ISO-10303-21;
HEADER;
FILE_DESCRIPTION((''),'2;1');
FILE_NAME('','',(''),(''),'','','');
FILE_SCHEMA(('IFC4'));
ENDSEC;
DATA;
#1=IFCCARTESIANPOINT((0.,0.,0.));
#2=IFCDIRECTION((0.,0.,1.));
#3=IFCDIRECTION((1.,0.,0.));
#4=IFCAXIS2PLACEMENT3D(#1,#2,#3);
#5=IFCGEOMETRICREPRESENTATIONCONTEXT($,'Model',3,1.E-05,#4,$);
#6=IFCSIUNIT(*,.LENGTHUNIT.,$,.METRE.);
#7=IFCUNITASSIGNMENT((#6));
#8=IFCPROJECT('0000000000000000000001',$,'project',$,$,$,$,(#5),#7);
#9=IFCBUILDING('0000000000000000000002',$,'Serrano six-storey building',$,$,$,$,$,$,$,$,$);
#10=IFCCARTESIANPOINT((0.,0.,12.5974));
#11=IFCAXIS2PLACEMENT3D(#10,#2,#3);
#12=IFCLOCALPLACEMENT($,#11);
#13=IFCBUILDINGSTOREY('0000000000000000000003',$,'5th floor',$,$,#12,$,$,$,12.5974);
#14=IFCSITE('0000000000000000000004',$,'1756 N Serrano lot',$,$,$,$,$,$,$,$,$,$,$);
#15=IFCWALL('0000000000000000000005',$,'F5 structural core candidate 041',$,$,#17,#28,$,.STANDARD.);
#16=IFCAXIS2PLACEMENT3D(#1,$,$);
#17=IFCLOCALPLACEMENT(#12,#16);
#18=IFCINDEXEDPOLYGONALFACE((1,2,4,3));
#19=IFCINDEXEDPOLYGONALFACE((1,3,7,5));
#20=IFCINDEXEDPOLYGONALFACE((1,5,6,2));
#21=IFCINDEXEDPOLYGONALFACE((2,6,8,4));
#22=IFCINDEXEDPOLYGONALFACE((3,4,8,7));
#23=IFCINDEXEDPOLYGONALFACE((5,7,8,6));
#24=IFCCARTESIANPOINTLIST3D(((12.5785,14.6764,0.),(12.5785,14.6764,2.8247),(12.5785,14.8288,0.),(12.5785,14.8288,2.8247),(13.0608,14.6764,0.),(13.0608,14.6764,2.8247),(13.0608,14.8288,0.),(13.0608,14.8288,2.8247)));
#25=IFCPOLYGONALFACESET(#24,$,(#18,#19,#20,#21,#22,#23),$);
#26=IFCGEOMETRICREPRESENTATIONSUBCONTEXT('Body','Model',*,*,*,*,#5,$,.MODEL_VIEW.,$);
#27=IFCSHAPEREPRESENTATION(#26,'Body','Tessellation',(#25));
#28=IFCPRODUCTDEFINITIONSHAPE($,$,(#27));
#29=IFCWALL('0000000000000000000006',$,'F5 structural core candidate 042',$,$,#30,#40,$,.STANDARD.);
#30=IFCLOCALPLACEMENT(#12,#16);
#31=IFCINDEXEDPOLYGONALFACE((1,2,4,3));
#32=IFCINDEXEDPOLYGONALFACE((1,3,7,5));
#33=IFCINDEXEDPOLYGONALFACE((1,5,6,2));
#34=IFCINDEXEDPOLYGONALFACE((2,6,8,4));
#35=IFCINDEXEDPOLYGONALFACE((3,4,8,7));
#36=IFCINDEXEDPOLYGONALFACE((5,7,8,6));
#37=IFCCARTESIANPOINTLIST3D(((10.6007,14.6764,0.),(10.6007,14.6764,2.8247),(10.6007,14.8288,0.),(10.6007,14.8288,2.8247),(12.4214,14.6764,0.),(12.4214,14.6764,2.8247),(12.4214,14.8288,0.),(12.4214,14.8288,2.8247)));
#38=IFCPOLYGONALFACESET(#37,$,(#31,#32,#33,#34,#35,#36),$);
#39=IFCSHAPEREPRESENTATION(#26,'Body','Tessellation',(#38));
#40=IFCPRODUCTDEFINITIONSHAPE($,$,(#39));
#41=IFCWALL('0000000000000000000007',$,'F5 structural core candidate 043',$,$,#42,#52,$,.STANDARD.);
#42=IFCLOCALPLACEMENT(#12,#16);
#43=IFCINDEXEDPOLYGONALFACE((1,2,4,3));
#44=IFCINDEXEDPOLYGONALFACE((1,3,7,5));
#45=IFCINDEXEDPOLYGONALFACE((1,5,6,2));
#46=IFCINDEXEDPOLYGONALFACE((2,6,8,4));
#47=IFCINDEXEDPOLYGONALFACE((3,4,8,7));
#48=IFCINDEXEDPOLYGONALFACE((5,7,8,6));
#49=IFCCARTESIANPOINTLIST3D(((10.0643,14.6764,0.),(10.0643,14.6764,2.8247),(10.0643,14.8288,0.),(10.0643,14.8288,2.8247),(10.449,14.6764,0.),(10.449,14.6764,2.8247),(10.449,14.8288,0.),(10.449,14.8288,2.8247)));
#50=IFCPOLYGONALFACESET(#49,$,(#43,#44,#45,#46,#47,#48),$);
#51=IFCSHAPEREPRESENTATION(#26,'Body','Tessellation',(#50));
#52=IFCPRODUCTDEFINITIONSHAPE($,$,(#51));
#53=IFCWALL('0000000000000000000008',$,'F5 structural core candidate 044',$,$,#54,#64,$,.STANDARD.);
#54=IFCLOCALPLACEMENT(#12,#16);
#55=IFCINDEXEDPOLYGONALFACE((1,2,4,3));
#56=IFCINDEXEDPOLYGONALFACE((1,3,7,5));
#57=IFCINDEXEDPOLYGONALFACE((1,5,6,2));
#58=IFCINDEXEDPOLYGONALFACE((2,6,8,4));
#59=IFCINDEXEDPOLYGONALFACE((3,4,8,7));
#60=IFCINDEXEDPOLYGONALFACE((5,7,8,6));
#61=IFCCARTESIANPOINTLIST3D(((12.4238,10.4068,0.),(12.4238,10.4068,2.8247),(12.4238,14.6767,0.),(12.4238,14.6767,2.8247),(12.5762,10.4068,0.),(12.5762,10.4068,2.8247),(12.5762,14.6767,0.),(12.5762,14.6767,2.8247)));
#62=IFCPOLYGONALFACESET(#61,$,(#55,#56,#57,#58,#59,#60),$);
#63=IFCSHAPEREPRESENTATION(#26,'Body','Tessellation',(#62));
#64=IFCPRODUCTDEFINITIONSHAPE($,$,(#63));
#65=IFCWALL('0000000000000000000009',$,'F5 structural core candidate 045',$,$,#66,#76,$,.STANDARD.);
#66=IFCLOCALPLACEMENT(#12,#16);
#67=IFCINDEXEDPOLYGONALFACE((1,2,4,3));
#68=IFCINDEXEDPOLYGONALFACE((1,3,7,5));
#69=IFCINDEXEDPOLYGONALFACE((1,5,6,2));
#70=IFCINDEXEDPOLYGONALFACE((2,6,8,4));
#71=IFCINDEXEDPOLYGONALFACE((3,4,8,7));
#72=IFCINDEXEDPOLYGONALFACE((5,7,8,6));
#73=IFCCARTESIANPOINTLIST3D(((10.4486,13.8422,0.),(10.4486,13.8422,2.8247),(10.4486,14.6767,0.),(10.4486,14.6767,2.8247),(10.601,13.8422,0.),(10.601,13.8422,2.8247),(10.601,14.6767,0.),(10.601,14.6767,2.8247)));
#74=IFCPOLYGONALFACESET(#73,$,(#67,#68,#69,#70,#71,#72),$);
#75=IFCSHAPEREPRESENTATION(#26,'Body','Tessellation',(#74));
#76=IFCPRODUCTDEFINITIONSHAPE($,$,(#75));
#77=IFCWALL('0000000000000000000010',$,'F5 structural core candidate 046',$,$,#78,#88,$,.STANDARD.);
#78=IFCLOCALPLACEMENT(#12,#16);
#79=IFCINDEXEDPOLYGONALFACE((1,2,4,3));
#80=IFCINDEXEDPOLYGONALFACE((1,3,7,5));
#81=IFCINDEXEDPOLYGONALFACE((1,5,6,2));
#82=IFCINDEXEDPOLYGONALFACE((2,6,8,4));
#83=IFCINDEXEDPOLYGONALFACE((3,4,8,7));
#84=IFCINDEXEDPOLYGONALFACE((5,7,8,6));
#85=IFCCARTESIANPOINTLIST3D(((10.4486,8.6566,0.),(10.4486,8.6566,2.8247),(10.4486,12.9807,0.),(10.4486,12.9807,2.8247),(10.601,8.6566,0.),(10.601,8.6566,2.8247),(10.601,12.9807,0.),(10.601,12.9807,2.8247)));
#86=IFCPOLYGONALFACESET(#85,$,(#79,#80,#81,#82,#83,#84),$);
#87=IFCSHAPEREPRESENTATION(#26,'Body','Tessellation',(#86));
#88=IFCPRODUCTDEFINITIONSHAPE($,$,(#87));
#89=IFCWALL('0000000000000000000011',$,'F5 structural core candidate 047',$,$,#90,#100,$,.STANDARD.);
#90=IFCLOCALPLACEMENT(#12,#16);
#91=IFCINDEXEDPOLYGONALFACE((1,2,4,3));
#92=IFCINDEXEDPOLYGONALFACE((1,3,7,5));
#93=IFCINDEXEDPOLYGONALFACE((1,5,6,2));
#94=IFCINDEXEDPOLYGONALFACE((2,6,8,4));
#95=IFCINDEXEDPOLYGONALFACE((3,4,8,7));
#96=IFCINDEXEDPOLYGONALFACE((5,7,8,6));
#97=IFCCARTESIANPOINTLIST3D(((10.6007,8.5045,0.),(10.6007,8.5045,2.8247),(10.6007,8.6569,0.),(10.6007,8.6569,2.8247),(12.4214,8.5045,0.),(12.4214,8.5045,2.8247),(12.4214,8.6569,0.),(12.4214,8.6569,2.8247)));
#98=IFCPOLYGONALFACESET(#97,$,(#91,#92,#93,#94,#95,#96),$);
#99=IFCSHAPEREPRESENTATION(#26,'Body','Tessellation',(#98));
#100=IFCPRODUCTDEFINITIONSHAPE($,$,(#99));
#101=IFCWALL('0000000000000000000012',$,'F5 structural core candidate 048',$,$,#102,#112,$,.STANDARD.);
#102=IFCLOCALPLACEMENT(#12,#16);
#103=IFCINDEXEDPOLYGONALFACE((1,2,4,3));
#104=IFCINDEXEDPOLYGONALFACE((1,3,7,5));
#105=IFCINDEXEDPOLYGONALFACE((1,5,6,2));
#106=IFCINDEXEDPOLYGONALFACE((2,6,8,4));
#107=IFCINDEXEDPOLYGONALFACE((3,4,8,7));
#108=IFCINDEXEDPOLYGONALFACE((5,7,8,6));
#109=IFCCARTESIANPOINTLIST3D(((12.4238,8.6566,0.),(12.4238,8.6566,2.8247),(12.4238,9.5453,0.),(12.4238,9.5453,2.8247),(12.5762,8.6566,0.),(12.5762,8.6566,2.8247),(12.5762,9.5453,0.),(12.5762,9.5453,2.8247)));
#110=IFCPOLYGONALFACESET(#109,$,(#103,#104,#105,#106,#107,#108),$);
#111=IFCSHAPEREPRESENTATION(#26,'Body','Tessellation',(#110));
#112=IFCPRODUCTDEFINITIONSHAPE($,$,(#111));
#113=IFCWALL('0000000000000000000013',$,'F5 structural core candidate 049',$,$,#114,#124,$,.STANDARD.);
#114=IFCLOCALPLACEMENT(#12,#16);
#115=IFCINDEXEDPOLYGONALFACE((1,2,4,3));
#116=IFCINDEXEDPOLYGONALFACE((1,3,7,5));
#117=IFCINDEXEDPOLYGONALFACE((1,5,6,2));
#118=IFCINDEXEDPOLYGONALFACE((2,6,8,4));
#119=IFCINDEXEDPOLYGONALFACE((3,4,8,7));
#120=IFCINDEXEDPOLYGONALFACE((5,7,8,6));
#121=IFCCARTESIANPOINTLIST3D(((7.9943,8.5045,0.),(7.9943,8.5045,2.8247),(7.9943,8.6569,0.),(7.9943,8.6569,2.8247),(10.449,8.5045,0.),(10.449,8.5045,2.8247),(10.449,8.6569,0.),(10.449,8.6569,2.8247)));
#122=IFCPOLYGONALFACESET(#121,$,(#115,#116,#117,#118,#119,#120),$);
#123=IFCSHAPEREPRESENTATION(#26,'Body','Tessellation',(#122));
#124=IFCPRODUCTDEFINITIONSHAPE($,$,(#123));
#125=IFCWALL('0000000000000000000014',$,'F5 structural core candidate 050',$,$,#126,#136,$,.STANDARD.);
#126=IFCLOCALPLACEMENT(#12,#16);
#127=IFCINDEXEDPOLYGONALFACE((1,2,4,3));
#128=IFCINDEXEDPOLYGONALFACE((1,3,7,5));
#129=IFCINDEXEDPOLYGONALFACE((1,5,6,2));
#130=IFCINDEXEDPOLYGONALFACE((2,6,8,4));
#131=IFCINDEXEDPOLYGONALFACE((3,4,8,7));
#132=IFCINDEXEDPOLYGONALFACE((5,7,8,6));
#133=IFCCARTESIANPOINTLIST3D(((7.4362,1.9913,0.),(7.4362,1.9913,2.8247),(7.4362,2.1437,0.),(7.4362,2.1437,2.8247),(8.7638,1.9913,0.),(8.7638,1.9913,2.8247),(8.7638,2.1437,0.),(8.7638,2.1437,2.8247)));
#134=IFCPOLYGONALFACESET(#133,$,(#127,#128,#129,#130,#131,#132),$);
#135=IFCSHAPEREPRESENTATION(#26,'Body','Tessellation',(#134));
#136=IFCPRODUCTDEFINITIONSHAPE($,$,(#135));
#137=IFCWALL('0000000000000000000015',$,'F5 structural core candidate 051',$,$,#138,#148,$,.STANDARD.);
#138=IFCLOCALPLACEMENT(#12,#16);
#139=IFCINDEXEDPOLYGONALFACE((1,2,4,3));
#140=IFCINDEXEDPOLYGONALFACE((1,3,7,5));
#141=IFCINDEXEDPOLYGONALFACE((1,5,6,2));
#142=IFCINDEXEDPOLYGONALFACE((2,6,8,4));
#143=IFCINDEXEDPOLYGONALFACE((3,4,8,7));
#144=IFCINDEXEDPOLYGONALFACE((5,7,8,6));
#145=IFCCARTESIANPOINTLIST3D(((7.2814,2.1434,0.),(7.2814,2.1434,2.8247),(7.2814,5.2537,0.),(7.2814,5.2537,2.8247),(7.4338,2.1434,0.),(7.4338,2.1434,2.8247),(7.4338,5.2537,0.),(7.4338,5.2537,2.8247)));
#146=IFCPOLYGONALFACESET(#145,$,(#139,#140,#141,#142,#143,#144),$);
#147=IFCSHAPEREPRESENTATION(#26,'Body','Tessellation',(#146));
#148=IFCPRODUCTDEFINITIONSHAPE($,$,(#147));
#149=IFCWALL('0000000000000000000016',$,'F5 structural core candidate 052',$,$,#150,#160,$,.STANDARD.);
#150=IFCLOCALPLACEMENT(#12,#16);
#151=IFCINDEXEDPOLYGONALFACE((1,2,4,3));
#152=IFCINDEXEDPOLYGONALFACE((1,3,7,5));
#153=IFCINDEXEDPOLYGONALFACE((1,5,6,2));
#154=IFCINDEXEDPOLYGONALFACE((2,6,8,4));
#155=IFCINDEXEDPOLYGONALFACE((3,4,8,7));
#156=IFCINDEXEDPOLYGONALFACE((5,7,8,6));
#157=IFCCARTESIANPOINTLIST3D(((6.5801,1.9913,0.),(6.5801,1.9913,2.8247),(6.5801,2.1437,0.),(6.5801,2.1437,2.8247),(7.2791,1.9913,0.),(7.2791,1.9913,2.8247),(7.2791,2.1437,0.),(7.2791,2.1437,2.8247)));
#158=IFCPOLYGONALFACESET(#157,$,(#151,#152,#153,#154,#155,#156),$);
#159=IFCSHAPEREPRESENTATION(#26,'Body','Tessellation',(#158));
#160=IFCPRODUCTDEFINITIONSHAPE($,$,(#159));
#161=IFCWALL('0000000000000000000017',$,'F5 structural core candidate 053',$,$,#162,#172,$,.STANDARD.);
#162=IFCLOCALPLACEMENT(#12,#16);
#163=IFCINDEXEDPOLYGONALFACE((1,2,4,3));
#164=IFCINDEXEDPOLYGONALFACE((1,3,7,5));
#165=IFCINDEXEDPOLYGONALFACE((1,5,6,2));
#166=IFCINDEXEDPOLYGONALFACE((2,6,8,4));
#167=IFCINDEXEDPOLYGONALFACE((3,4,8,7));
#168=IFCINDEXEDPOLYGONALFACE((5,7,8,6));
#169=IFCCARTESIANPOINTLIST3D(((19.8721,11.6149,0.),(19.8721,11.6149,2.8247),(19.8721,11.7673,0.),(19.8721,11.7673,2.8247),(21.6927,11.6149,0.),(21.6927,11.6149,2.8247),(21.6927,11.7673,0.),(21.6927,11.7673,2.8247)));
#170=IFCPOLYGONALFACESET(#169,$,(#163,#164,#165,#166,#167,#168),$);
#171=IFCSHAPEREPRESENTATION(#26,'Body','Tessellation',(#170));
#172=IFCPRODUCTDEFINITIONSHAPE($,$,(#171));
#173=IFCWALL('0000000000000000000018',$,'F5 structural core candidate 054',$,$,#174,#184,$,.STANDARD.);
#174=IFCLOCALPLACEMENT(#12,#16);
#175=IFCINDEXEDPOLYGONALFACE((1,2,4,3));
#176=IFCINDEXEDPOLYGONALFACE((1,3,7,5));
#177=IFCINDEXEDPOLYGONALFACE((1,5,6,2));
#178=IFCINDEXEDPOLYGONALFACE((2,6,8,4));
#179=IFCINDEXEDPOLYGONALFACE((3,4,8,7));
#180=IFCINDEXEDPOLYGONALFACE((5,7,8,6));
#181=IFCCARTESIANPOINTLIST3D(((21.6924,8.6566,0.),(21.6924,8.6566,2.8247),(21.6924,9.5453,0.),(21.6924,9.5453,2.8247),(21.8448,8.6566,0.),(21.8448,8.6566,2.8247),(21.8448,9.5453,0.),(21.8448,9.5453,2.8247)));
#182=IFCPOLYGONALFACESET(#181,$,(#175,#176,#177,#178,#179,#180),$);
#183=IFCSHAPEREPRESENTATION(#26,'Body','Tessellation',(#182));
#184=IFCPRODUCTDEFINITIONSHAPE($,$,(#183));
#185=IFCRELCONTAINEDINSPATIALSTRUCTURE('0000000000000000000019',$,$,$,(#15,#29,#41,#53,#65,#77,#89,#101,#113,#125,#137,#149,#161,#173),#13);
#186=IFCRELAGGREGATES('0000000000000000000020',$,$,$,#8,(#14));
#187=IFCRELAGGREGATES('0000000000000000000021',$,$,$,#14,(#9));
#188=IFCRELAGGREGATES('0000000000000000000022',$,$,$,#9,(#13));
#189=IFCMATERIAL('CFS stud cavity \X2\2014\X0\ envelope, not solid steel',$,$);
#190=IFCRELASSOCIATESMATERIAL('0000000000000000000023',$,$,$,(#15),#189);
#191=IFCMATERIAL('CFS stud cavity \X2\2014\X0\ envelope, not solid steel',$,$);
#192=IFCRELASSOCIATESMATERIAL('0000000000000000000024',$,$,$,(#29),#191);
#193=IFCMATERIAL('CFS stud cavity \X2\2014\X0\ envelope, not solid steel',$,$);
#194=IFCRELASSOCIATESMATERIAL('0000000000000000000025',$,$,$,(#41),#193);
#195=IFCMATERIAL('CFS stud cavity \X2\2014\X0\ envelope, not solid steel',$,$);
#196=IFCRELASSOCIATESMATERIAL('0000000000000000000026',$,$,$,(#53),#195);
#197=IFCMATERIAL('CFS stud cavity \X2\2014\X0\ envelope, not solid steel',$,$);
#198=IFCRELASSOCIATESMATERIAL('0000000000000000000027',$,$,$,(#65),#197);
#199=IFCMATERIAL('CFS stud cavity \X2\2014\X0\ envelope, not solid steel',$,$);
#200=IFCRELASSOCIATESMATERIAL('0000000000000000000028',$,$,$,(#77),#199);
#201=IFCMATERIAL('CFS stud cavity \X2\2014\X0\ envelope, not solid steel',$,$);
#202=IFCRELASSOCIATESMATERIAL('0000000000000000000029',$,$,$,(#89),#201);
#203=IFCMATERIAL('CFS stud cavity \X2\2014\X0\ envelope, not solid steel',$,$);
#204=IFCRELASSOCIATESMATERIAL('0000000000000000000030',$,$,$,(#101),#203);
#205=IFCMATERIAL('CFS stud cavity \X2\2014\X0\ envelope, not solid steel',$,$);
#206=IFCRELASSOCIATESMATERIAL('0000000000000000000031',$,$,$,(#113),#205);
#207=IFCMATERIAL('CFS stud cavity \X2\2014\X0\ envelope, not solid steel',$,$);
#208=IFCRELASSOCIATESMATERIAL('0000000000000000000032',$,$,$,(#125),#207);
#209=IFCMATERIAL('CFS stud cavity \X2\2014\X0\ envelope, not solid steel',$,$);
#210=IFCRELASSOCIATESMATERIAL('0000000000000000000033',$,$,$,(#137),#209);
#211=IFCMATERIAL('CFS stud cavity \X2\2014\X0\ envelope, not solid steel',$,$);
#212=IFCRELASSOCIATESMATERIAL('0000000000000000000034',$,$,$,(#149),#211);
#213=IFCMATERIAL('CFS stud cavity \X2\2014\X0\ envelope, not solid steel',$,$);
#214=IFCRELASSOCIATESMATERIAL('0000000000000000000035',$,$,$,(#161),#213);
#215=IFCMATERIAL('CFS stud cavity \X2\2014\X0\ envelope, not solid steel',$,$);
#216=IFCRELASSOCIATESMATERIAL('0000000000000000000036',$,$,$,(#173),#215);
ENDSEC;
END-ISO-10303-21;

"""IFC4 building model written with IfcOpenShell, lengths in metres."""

from ifc_helpers import new_model, si_unit, frame, origin_with_axes, place, context, subcontext, project, spatial, polyline, outline, extrude, material, element, save


model = new_model("IFC4")

# Units and contexts
model_context = context("Model", 3, precision=1e-05, world=origin_with_axes())
body_context = subcontext(model_context, "Body", "Model", "MODEL_VIEW")
ifc_project = project(units=[si_unit("LENGTHUNIT", "METRE")], contexts=[model_context])

# Site, building, storey
site = spatial("IfcSite", under=ifc_project, Name="1756 N Serrano lot")
building = spatial("IfcBuilding", under=site, Name="Serrano six-storey building")
storey_placement = place(None, frame((0.0, 0.0, 12.5974), z_axis=(0.0, 0.0, 1.0), x_axis=(1.0, 0.0, 0.0)))
storey = spatial("IfcBuildingStorey", under=building, at=storey_placement, Name="5th floor", Elevation=12.5974)

# Walls
ifc_material_1 = material(Name="CFS stud cavity — envelope, not solid steel")
wall_1_placement = place(storey_placement, frame((0.0, 0.0, -12.5974), z_axis=(0.0, 0.0, 1.0), x_axis=(1.0, 0.0, 0.0)))
element("IfcWall", 1, at=wall_1_placement, inside=storey, material=ifc_material_1, Name="F5 structural core candidate 041", PredefinedType="STANDARD", context=body_context, shape_type="SweptSolid", body=[
    extrude(outline(polyline([(13.0608, 14.8288), (13.0608, 14.6764), (12.5785, 14.6764), (12.5785, 14.8288), (13.0608, 14.8288)])), frame((0.0, 0.0, 12.5974)), (0.0, 0.0, 1.0), 2.8247),
])
ifc_material_2 = material(Name="CFS stud cavity — envelope, not solid steel")
wall_2_placement = place(storey_placement, frame((0.0, 0.0, -12.5974), z_axis=(0.0, 0.0, 1.0), x_axis=(1.0, 0.0, 0.0)))
element("IfcWall", 2, at=wall_2_placement, inside=storey, material=ifc_material_2, Name="F5 structural core candidate 042", PredefinedType="STANDARD", context=body_context, shape_type="SweptSolid", body=[
    extrude(outline(polyline([(12.4214, 14.8288), (12.4214, 14.6764), (10.6007, 14.6764), (10.6007, 14.8288), (12.4214, 14.8288)])), frame((0.0, 0.0, 12.5974)), (0.0, 0.0, 1.0), 2.8247),
])
ifc_material_3 = material(Name="CFS stud cavity — envelope, not solid steel")
wall_3_placement = place(storey_placement, frame((0.0, 0.0, -12.5974), z_axis=(0.0, 0.0, 1.0), x_axis=(1.0, 0.0, 0.0)))
element("IfcWall", 3, at=wall_3_placement, inside=storey, material=ifc_material_3, Name="F5 structural core candidate 043", PredefinedType="STANDARD", context=body_context, shape_type="SweptSolid", body=[
    extrude(outline(polyline([(10.449, 14.8288), (10.449, 14.6764), (10.0643, 14.6764), (10.0643, 14.8288), (10.449, 14.8288)])), frame((0.0, 0.0, 12.5974)), (0.0, 0.0, 1.0), 2.8247),
])
ifc_material_4 = material(Name="CFS stud cavity — envelope, not solid steel")
wall_4_placement = place(storey_placement, frame((0.0, 0.0, -12.5974), z_axis=(0.0, 0.0, 1.0), x_axis=(1.0, 0.0, 0.0)))
element("IfcWall", 4, at=wall_4_placement, inside=storey, material=ifc_material_4, Name="F5 structural core candidate 044", PredefinedType="STANDARD", context=body_context, shape_type="SweptSolid", body=[
    extrude(outline(polyline([(12.5762, 10.4068), (12.4238, 10.4068), (12.4238, 14.6767), (12.5762, 14.6767), (12.5762, 10.4068)])), frame((0.0, 0.0, 12.5974)), (0.0, 0.0, 1.0), 2.8247),
])
ifc_material_5 = material(Name="CFS stud cavity — envelope, not solid steel")
wall_5_placement = place(storey_placement, frame((0.0, 0.0, -12.5974), z_axis=(0.0, 0.0, 1.0), x_axis=(1.0, 0.0, 0.0)))
element("IfcWall", 5, at=wall_5_placement, inside=storey, material=ifc_material_5, Name="F5 structural core candidate 045", PredefinedType="STANDARD", context=body_context, shape_type="SweptSolid", body=[
    extrude(outline(polyline([(10.601, 13.8422), (10.4486, 13.8422), (10.4486, 14.6767), (10.601, 14.6767), (10.601, 13.8422)])), frame((0.0, 0.0, 12.5974)), (0.0, 0.0, 1.0), 2.8247),
])
ifc_material_6 = material(Name="CFS stud cavity — envelope, not solid steel")
wall_6_placement = place(storey_placement, frame((0.0, 0.0, -12.5974), z_axis=(0.0, 0.0, 1.0), x_axis=(1.0, 0.0, 0.0)))
element("IfcWall", 6, at=wall_6_placement, inside=storey, material=ifc_material_6, Name="F5 structural core candidate 046", PredefinedType="STANDARD", context=body_context, shape_type="SweptSolid", body=[
    extrude(outline(polyline([(10.601, 8.6566), (10.4486, 8.6566), (10.4486, 12.9807), (10.601, 12.9807), (10.601, 8.6566)])), frame((0.0, 0.0, 12.5974)), (0.0, 0.0, 1.0), 2.8247),
])
ifc_material_7 = material(Name="CFS stud cavity — envelope, not solid steel")
wall_7_placement = place(storey_placement, frame((0.0, 0.0, -12.5974), z_axis=(0.0, 0.0, 1.0), x_axis=(1.0, 0.0, 0.0)))
element("IfcWall", 7, at=wall_7_placement, inside=storey, material=ifc_material_7, Name="F5 structural core candidate 047", PredefinedType="STANDARD", context=body_context, shape_type="SweptSolid", body=[
    extrude(outline(polyline([(12.4214, 8.6569), (12.4214, 8.5045), (10.6007, 8.5045), (10.6007, 8.6569), (12.4214, 8.6569)])), frame((0.0, 0.0, 12.5974)), (0.0, 0.0, 1.0), 2.8247),
])
ifc_material_8 = material(Name="CFS stud cavity — envelope, not solid steel")
wall_8_placement = place(storey_placement, frame((0.0, 0.0, -12.5974), z_axis=(0.0, 0.0, 1.0), x_axis=(1.0, 0.0, 0.0)))
element("IfcWall", 8, at=wall_8_placement, inside=storey, material=ifc_material_8, Name="F5 structural core candidate 048", PredefinedType="STANDARD", context=body_context, shape_type="SweptSolid", body=[
    extrude(outline(polyline([(12.5762, 8.6566), (12.4238, 8.6566), (12.4238, 9.5453), (12.5762, 9.5453), (12.5762, 8.6566)])), frame((0.0, 0.0, 12.5974)), (0.0, 0.0, 1.0), 2.8247),
])
ifc_material_9 = material(Name="CFS stud cavity — envelope, not solid steel")
wall_9_placement = place(storey_placement, frame((0.0, 0.0, -12.5974), z_axis=(0.0, 0.0, 1.0), x_axis=(1.0, 0.0, 0.0)))
element("IfcWall", 9, at=wall_9_placement, inside=storey, material=ifc_material_9, Name="F5 structural core candidate 049", PredefinedType="STANDARD", context=body_context, shape_type="SweptSolid", body=[
    extrude(outline(polyline([(10.449, 8.6569), (10.449, 8.5045), (7.9943, 8.5045), (7.9943, 8.6569), (10.449, 8.6569)])), frame((0.0, 0.0, 12.5974)), (0.0, 0.0, 1.0), 2.8247),
])
ifc_material_10 = material(Name="CFS stud cavity — envelope, not solid steel")
wall_10_placement = place(storey_placement, frame((0.0, 0.0, -12.5974), z_axis=(0.0, 0.0, 1.0), x_axis=(1.0, 0.0, 0.0)))
element("IfcWall", 10, at=wall_10_placement, inside=storey, material=ifc_material_10, Name="F5 structural core candidate 050", PredefinedType="STANDARD", context=body_context, shape_type="SweptSolid", body=[
    extrude(outline(polyline([(8.7638, 2.1437), (8.7638, 1.9913), (7.4362, 1.9913), (7.4362, 2.1437), (8.7638, 2.1437)])), frame((0.0, 0.0, 12.5974)), (0.0, 0.0, 1.0), 2.8247),
])
ifc_material_11 = material(Name="CFS stud cavity — envelope, not solid steel")
wall_11_placement = place(storey_placement, frame((0.0, 0.0, -12.5974), z_axis=(0.0, 0.0, 1.0), x_axis=(1.0, 0.0, 0.0)))
element("IfcWall", 11, at=wall_11_placement, inside=storey, material=ifc_material_11, Name="F5 structural core candidate 051", PredefinedType="STANDARD", context=body_context, shape_type="SweptSolid", body=[
    extrude(outline(polyline([(7.4338, 2.1434), (7.2814, 2.1434), (7.2814, 5.2537), (7.4338, 5.2537), (7.4338, 2.1434)])), frame((0.0, 0.0, 12.5974)), (0.0, 0.0, 1.0), 2.8247),
])
ifc_material_12 = material(Name="CFS stud cavity — envelope, not solid steel")
wall_12_placement = place(storey_placement, frame((0.0, 0.0, -12.5974), z_axis=(0.0, 0.0, 1.0), x_axis=(1.0, 0.0, 0.0)))
element("IfcWall", 12, at=wall_12_placement, inside=storey, material=ifc_material_12, Name="F5 structural core candidate 052", PredefinedType="STANDARD", context=body_context, shape_type="SweptSolid", body=[
    extrude(outline(polyline([(7.2791, 2.1437), (7.2791, 1.9913), (6.5801, 1.9913), (6.5801, 2.1437), (7.2791, 2.1437)])), frame((0.0, 0.0, 12.5974)), (0.0, 0.0, 1.0), 2.8247),
])
ifc_material_13 = material(Name="CFS stud cavity — envelope, not solid steel")
wall_13_placement = place(storey_placement, frame((0.0, 0.0, -12.5974), z_axis=(0.0, 0.0, 1.0), x_axis=(1.0, 0.0, 0.0)))
element("IfcWall", 13, at=wall_13_placement, inside=storey, material=ifc_material_13, Name="F5 structural core candidate 053", PredefinedType="STANDARD", context=body_context, shape_type="SweptSolid", body=[
    extrude(outline(polyline([(21.6927, 11.7673), (21.6927, 11.6149), (19.8721, 11.6149), (19.8721, 11.7673), (21.6927, 11.7673)])), frame((0.0, 0.0, 12.5974)), (0.0, 0.0, 1.0), 2.8247),
])
ifc_material_14 = material(Name="CFS stud cavity — envelope, not solid steel")
wall_14_placement = place(storey_placement, frame((0.0, 0.0, -12.5974), z_axis=(0.0, 0.0, 1.0), x_axis=(1.0, 0.0, 0.0)))
element("IfcWall", 14, at=wall_14_placement, inside=storey, material=ifc_material_14, Name="F5 structural core candidate 054", PredefinedType="STANDARD", context=body_context, shape_type="SweptSolid", body=[
    extrude(outline(polyline([(21.8448, 8.6566), (21.6924, 8.6566), (21.6924, 9.5453), (21.8448, 9.5453), (21.8448, 8.6566)])), frame((0.0, 0.0, 12.5974)), (0.0, 0.0, 1.0), 2.8247),
])

save(model, "model.ifc")
